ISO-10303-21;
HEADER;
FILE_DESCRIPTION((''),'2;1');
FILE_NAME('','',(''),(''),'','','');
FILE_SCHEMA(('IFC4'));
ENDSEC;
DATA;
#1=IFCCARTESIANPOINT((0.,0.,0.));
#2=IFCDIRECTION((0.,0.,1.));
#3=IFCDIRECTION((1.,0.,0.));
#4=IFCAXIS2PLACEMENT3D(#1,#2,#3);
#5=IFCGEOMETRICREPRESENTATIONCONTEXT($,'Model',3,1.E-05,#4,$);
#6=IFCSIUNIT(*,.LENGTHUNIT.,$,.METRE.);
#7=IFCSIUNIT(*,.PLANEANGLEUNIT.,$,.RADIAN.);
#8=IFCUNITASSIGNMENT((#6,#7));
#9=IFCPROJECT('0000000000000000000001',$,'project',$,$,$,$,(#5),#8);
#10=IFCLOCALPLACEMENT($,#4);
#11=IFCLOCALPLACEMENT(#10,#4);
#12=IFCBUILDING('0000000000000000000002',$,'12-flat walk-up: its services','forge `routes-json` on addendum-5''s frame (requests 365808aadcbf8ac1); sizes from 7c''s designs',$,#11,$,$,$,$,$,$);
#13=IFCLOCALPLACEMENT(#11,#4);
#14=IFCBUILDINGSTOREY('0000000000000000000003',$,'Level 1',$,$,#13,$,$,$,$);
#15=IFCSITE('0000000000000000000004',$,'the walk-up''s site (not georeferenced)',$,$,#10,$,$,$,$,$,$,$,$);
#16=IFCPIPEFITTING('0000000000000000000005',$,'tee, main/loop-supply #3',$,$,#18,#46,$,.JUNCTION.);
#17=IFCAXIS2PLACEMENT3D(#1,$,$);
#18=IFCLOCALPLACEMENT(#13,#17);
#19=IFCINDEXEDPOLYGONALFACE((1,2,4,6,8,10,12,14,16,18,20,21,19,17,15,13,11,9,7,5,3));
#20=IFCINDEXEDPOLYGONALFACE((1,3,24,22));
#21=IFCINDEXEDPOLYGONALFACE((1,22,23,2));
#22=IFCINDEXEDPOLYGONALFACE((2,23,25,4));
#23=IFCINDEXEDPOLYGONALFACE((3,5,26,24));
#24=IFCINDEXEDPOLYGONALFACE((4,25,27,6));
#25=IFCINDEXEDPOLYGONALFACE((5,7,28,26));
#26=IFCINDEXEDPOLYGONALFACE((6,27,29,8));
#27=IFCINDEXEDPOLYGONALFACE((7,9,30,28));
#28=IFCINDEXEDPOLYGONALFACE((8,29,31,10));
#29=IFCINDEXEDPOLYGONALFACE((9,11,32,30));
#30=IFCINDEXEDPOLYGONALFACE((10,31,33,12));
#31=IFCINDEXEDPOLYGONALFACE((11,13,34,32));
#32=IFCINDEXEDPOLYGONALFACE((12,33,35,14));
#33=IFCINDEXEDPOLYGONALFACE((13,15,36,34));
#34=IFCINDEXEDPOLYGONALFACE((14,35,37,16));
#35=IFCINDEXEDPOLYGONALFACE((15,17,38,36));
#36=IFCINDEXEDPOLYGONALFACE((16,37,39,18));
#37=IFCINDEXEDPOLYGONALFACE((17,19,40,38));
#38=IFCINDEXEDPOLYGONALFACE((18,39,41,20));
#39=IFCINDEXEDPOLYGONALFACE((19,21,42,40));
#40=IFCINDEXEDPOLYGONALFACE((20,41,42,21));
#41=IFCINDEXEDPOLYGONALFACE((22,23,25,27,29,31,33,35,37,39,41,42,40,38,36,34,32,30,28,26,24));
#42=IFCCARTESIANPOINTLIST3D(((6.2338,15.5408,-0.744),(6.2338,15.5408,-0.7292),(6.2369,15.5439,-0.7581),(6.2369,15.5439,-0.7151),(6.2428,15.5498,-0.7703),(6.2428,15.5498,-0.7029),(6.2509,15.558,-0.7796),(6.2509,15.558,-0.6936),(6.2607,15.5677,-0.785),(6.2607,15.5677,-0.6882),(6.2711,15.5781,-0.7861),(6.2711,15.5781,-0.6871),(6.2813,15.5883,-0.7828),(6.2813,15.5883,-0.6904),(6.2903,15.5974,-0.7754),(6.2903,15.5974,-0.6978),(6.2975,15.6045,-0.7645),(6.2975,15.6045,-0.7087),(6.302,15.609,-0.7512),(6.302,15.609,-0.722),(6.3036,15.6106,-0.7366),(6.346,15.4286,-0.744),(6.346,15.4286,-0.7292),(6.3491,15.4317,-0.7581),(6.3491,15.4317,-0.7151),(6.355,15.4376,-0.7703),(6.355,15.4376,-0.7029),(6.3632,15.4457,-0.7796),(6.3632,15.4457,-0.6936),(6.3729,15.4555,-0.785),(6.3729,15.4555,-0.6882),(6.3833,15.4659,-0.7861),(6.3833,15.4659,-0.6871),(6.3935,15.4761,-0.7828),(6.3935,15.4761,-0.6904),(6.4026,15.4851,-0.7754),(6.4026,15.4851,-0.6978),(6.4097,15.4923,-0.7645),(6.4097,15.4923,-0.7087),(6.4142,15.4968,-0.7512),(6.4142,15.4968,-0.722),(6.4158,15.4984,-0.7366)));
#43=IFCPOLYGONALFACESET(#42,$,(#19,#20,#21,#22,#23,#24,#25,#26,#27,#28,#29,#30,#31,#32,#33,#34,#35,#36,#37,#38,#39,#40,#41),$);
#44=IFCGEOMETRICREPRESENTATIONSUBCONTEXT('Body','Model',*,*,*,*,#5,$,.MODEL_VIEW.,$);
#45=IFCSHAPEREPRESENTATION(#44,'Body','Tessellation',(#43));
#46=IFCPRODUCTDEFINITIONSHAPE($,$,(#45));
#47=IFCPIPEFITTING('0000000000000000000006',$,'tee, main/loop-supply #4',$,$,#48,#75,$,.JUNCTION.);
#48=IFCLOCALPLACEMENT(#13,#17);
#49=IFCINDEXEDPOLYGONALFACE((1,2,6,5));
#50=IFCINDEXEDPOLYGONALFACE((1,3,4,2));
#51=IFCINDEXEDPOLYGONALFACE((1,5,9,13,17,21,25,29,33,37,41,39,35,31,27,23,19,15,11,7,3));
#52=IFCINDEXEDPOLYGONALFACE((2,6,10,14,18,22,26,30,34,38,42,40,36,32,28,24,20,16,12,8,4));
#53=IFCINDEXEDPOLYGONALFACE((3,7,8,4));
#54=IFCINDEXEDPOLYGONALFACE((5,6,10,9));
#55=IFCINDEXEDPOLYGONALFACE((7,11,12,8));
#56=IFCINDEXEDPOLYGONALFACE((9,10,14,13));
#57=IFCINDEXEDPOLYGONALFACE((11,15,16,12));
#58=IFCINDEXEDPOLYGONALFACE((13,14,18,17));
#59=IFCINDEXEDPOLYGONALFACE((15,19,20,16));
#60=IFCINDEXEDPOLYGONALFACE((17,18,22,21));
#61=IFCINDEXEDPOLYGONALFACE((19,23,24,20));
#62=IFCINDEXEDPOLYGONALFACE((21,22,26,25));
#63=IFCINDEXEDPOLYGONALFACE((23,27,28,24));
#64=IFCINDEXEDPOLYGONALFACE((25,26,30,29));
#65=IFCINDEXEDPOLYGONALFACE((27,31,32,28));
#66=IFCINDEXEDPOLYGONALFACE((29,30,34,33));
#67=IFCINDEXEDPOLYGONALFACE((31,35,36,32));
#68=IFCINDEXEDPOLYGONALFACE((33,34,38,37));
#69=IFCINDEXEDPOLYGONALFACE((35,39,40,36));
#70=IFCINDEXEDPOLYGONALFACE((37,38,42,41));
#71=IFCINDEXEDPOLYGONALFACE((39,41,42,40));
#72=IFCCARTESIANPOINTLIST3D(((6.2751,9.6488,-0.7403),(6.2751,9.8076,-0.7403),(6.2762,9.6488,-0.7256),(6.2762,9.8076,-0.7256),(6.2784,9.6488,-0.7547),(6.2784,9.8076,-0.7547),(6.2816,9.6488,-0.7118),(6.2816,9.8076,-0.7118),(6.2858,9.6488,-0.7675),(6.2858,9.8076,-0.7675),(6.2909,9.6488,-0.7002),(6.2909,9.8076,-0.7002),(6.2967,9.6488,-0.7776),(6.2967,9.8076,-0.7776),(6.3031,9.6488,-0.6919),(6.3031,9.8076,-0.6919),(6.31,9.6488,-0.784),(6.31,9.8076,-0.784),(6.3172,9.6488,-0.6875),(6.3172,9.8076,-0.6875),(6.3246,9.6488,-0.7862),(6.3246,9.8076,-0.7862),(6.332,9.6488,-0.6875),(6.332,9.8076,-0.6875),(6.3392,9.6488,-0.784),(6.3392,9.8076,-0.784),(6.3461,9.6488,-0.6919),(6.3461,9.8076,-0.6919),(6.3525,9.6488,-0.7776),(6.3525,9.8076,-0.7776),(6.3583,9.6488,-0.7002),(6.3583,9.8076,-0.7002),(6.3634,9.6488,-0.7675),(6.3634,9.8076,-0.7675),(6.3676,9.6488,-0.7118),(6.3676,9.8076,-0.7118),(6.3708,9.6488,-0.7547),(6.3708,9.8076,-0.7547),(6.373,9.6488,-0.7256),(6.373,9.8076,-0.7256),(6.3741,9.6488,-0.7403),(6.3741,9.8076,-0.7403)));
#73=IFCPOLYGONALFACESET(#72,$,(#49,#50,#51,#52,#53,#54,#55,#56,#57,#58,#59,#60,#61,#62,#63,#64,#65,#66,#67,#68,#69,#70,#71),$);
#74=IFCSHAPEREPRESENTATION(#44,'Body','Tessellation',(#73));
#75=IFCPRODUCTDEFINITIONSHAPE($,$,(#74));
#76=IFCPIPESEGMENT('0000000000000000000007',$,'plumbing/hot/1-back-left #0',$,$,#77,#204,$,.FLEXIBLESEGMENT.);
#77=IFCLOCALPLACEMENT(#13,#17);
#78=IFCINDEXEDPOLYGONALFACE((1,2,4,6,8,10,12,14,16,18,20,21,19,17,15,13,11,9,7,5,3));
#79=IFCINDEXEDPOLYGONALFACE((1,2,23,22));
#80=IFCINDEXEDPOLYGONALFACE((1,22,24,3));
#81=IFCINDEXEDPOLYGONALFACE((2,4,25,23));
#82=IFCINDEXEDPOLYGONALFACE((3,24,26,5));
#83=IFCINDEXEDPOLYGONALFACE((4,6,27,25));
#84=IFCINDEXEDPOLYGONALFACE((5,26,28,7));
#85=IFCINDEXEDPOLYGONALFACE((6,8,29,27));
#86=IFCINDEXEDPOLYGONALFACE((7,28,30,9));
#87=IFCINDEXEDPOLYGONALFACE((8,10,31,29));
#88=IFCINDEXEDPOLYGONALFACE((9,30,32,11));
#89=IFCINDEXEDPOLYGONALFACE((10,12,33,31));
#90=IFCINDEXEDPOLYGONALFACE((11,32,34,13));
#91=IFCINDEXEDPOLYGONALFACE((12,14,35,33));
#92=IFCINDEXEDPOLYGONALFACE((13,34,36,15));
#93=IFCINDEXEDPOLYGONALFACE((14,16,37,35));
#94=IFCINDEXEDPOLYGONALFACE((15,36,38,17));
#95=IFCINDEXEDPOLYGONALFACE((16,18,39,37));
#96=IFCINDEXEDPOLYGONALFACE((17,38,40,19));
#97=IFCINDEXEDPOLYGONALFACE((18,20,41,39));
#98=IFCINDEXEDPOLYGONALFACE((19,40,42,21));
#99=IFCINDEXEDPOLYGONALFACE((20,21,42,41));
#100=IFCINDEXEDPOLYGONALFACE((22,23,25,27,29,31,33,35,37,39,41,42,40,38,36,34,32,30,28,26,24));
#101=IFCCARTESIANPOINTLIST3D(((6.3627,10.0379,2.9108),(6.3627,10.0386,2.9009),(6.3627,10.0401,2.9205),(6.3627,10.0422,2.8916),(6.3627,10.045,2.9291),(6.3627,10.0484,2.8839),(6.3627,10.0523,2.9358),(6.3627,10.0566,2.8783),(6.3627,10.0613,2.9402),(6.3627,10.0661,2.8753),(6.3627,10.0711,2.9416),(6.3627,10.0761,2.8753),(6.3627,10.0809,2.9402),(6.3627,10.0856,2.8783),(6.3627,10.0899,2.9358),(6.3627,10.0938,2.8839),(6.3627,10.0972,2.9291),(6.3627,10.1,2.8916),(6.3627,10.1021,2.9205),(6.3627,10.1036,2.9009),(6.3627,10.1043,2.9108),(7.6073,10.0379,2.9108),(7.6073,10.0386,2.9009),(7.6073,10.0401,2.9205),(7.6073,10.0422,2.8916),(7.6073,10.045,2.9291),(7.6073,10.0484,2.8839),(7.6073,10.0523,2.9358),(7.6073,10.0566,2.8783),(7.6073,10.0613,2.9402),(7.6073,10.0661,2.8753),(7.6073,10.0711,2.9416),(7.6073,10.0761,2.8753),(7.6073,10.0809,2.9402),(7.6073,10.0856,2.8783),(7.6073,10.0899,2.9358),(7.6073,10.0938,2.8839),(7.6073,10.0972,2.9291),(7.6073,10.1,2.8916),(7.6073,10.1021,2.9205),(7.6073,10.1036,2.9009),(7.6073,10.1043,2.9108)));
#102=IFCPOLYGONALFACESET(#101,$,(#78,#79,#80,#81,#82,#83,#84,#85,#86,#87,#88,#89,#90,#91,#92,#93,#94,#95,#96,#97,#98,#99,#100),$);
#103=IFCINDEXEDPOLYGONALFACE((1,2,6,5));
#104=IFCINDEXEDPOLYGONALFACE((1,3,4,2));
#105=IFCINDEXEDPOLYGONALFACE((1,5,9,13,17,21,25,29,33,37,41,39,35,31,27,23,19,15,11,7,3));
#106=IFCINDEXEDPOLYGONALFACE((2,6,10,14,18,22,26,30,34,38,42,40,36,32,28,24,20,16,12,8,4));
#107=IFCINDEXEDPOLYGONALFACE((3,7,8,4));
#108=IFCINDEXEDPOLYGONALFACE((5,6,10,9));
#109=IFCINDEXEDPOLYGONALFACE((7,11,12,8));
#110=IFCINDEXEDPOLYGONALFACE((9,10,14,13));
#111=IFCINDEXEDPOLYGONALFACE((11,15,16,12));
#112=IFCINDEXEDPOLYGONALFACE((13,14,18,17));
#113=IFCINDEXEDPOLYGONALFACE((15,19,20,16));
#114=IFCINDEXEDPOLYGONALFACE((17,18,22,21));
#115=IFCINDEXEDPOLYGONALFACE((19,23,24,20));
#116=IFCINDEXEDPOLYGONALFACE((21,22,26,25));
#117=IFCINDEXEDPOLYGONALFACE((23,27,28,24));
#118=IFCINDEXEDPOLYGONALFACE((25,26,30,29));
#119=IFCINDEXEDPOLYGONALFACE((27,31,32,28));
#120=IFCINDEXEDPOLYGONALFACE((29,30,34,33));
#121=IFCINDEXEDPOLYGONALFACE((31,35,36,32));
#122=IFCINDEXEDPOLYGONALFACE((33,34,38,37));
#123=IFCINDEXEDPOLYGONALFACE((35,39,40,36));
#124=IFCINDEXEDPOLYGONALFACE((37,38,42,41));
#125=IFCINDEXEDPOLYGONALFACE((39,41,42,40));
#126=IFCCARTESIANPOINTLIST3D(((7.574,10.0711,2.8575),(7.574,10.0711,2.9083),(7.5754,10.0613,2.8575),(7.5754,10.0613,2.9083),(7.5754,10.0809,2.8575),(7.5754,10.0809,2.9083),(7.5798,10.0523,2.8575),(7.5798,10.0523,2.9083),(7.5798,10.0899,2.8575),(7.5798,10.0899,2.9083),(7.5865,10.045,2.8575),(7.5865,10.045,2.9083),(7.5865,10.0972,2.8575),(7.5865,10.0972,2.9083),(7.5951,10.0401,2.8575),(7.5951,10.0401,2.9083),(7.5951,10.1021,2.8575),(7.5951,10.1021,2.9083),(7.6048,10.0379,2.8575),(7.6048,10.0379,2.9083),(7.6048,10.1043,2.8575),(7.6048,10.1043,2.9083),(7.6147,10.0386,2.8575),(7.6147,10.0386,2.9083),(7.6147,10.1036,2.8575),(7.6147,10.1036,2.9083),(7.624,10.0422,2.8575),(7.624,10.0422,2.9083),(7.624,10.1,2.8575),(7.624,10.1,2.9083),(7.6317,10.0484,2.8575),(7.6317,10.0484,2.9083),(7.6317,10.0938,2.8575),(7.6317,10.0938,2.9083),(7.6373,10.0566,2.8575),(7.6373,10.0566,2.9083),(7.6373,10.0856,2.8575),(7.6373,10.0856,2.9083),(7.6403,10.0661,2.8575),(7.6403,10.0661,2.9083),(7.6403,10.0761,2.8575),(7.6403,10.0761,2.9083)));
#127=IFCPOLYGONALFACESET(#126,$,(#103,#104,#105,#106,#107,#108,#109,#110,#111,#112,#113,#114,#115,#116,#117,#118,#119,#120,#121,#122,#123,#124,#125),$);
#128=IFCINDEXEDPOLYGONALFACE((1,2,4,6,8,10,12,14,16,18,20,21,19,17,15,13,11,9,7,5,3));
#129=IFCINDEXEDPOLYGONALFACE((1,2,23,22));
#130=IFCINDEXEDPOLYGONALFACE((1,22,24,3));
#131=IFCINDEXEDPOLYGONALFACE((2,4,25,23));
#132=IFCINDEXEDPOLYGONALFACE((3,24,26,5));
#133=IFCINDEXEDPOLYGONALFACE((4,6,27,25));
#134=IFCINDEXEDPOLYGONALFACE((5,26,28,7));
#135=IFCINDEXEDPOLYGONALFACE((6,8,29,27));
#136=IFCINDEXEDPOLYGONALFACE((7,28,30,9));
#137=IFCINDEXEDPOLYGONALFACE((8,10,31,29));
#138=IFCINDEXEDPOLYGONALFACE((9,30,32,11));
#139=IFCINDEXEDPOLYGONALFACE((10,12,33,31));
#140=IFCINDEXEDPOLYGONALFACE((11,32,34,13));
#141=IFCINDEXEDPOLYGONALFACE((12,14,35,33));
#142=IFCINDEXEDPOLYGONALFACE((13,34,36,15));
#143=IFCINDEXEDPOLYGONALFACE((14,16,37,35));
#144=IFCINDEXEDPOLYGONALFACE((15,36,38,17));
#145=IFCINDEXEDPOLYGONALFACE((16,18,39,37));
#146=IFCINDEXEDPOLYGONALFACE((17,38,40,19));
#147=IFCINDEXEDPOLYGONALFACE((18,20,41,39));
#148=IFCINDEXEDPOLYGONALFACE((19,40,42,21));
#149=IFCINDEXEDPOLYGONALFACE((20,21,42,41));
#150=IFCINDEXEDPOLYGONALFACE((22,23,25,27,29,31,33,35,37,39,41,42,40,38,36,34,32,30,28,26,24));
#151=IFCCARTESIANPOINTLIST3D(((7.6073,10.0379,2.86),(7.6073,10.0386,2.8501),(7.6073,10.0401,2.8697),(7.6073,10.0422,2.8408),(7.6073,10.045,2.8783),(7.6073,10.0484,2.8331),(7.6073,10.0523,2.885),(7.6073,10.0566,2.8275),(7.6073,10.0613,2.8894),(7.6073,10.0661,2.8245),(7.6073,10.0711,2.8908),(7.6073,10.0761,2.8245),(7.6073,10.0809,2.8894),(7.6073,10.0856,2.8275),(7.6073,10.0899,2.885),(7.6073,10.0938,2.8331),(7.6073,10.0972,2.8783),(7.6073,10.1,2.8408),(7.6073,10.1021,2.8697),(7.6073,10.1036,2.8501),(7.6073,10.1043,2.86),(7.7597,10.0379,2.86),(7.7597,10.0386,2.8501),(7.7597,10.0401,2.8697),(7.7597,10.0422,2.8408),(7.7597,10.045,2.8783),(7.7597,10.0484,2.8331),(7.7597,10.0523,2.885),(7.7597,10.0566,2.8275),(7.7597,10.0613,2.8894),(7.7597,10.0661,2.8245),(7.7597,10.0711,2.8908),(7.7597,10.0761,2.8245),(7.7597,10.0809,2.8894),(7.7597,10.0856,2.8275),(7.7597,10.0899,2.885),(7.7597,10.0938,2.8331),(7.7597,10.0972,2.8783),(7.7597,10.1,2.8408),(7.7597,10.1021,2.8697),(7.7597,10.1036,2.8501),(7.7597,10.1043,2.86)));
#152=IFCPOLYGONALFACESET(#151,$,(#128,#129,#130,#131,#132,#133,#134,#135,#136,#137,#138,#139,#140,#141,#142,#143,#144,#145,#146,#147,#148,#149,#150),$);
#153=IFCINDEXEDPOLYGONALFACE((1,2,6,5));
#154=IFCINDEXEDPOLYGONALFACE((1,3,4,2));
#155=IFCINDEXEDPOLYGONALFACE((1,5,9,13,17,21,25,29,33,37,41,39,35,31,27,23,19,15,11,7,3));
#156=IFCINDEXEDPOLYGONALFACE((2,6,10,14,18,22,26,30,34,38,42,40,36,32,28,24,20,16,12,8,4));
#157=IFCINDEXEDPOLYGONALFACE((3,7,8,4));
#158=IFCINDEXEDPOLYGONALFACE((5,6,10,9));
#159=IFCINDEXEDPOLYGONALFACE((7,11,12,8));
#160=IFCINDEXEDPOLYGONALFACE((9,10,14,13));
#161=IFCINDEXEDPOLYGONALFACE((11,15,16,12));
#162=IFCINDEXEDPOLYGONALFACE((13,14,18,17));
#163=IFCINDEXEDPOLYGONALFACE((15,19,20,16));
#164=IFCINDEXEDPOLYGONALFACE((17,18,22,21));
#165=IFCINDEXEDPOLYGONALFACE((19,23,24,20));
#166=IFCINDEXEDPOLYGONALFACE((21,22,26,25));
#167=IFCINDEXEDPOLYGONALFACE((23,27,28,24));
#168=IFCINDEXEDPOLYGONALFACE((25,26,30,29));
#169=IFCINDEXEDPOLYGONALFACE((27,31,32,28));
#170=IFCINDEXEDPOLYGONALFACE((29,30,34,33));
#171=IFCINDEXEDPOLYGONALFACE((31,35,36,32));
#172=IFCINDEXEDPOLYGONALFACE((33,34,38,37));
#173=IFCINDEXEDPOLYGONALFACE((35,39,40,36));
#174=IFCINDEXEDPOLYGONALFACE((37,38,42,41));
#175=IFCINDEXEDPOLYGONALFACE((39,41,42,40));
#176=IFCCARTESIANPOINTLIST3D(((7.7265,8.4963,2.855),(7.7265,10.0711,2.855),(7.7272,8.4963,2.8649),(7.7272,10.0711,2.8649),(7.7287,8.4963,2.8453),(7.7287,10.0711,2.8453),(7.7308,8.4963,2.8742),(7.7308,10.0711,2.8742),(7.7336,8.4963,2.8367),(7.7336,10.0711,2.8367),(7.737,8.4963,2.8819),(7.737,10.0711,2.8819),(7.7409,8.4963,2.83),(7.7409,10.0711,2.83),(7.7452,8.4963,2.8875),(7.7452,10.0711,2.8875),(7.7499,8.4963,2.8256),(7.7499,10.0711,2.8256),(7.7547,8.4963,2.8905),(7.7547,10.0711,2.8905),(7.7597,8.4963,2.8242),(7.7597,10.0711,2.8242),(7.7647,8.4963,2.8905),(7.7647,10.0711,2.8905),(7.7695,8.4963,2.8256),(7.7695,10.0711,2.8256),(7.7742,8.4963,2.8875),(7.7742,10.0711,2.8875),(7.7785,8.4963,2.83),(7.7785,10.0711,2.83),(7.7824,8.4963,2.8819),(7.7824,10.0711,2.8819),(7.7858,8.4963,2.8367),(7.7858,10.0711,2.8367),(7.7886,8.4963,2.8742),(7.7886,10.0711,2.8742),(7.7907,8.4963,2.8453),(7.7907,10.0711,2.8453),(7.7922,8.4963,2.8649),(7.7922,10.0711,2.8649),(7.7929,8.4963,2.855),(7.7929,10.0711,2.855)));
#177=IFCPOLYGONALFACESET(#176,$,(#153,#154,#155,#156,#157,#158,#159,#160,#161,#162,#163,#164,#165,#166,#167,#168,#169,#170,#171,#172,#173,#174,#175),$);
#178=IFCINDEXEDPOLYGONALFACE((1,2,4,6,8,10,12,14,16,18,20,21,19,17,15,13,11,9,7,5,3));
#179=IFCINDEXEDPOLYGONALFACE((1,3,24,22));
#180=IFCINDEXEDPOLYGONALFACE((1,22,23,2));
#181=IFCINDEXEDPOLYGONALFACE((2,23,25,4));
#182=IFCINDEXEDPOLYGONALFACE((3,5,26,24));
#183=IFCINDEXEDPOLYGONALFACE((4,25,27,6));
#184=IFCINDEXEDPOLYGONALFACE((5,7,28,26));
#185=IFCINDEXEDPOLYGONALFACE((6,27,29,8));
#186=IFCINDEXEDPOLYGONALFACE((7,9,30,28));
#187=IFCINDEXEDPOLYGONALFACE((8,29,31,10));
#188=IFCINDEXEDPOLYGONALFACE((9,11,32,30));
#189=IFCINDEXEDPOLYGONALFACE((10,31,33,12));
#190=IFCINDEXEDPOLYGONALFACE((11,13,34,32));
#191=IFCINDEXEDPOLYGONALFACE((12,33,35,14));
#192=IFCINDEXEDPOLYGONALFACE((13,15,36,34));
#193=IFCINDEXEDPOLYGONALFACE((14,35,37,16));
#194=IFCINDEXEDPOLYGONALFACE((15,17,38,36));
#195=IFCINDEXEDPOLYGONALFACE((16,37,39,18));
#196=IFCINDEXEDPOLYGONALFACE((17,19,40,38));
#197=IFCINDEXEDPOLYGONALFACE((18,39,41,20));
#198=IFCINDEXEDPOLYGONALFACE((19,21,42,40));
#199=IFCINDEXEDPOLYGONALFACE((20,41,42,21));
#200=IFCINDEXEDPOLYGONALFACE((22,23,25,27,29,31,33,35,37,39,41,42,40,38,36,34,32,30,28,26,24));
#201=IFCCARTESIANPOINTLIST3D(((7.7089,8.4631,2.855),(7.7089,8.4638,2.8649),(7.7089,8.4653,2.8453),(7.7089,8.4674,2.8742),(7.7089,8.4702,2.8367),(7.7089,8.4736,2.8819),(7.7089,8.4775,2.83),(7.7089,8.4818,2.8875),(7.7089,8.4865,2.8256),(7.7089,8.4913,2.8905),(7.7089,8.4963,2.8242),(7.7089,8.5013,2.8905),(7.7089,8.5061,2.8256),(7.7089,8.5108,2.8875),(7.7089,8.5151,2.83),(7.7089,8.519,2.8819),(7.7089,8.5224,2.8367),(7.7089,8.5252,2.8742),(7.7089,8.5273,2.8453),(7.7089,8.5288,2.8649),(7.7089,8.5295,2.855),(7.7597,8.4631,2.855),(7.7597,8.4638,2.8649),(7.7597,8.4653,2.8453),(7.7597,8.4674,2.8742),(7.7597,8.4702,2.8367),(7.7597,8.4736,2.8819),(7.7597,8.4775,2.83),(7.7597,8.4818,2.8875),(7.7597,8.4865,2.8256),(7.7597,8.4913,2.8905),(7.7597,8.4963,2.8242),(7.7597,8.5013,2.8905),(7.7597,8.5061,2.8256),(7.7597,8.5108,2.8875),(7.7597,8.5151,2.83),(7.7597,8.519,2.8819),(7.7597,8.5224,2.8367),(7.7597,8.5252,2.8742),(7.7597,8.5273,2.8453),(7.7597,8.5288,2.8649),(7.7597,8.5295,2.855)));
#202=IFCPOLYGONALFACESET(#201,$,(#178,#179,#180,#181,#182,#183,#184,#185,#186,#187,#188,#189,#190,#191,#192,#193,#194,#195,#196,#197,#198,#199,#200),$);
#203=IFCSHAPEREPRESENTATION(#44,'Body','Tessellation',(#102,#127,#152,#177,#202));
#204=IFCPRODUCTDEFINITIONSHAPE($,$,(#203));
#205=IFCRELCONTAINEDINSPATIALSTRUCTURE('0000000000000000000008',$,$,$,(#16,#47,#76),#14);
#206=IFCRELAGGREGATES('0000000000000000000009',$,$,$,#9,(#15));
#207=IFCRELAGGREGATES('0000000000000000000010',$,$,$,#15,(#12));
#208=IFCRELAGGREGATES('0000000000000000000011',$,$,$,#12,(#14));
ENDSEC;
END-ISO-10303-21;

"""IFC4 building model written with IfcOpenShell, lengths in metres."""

from ifc_helpers import new_model, entity, si_unit, frame, origin_with_axes, place, context, subcontext, project, spatial, element, save


model = new_model("IFC4")

# Units and contexts
model_context = context("Model", 3, precision=1e-05, world=origin_with_axes())
body_context = subcontext(model_context, "Body", "Model", "MODEL_VIEW")
ifc_project = project(units=[si_unit("LENGTHUNIT", "METRE"), si_unit("PLANEANGLEUNIT", "RADIAN")], contexts=[model_context])

# Site, building, storey
site_placement = place(None, origin_with_axes())
site = spatial("IfcSite", under=ifc_project, at=site_placement, Name="the walk-up's site (not georeferenced)")
building_placement = place(site_placement, origin_with_axes())
building = spatial("IfcBuilding", under=site, at=building_placement, Name="12-flat walk-up: its services", Description="forge `routes-json` on addendum-5's frame (requests 365808aadcbf8ac1); sizes from 7c's designs")
storey_placement = place(building_placement, origin_with_axes())
storey = spatial("IfcBuildingStorey", under=building, at=storey_placement, Name="Level 1")

# Pipe fittings
pipe_fitting_1_placement = place(storey_placement, frame((6.3807, 15.4633, -0.7366), z_axis=(0.0, 0.0, 1.0), x_axis=(1.0, 0.0, 0.0)))
element("IfcPipeFitting", 1, at=pipe_fitting_1_placement, inside=storey, Name="tee, main/loop-supply #3", PredefinedType="JUNCTION", context=body_context, shape_type="AdvancedSweptSolid", body=[
    entity("IfcSweptDiskSolid", entity("IfcPolyline", [entity("IfcCartesianPoint", [0.0, 0.0, 0.0]), entity("IfcCartesianPoint", [-0.1123, 0.1123, 0.0])]), 0.0496),
])
pipe_fitting_2_placement = place(storey_placement, frame((6.3246, 9.8076, -0.7366), z_axis=(0.0, 0.0, 1.0), x_axis=(1.0, 0.0, 0.0)))
element("IfcPipeFitting", 2, at=pipe_fitting_2_placement, inside=storey, Name="tee, main/loop-supply #4", PredefinedType="JUNCTION", context=body_context, shape_type="AdvancedSweptSolid", body=[
    entity("IfcSweptDiskSolid", entity("IfcPolyline", [entity("IfcCartesianPoint", [0.0, 0.0, 0.0]), entity("IfcCartesianPoint", [0.0, -0.1588, 0.0])]), 0.0496),
])

# Pipe segment
pipe_segment_1_placement = place(storey_placement, frame((6.3627, 10.0711, 2.9083), z_axis=(0.0, 0.0, 1.0), x_axis=(1.0, 0.0, 0.0)))
element("IfcPipeSegment", 3, at=pipe_segment_1_placement, inside=storey, Name="plumbing/hot/1-back-left #0", PredefinedType="FLEXIBLESEGMENT", context=body_context, shape_type="AdvancedSweptSolid", body=[
    entity("IfcSweptDiskSolid", entity("IfcPolyline", [entity("IfcCartesianPoint", [0.0, 0.0, 0.0]), entity("IfcCartesianPoint", [1.2446, 0.0, 0.0])]), 0.0333),
    entity("IfcSweptDiskSolid", entity("IfcPolyline", [entity("IfcCartesianPoint", [1.2446, 0.0, 0.0]), entity("IfcCartesianPoint", [1.2446, 0.0, -0.0508])]), 0.0333),
    entity("IfcSweptDiskSolid", entity("IfcPolyline", [entity("IfcCartesianPoint", [1.2446, 0.0, -0.0508]), entity("IfcCartesianPoint", [1.397, 0.0, -0.0508])]), 0.0333),
    entity("IfcSweptDiskSolid", entity("IfcPolyline", [entity("IfcCartesianPoint", [1.397, 0.0, -0.0508]), entity("IfcCartesianPoint", [1.397, -1.5748, -0.0508])]), 0.0333),
    entity("IfcSweptDiskSolid", entity("IfcPolyline", [entity("IfcCartesianPoint", [1.397, -1.5748, -0.0508]), entity("IfcCartesianPoint", [1.3462, -1.5748, -0.0508])]), 0.0333),
])

save(model, "model.ifc")
